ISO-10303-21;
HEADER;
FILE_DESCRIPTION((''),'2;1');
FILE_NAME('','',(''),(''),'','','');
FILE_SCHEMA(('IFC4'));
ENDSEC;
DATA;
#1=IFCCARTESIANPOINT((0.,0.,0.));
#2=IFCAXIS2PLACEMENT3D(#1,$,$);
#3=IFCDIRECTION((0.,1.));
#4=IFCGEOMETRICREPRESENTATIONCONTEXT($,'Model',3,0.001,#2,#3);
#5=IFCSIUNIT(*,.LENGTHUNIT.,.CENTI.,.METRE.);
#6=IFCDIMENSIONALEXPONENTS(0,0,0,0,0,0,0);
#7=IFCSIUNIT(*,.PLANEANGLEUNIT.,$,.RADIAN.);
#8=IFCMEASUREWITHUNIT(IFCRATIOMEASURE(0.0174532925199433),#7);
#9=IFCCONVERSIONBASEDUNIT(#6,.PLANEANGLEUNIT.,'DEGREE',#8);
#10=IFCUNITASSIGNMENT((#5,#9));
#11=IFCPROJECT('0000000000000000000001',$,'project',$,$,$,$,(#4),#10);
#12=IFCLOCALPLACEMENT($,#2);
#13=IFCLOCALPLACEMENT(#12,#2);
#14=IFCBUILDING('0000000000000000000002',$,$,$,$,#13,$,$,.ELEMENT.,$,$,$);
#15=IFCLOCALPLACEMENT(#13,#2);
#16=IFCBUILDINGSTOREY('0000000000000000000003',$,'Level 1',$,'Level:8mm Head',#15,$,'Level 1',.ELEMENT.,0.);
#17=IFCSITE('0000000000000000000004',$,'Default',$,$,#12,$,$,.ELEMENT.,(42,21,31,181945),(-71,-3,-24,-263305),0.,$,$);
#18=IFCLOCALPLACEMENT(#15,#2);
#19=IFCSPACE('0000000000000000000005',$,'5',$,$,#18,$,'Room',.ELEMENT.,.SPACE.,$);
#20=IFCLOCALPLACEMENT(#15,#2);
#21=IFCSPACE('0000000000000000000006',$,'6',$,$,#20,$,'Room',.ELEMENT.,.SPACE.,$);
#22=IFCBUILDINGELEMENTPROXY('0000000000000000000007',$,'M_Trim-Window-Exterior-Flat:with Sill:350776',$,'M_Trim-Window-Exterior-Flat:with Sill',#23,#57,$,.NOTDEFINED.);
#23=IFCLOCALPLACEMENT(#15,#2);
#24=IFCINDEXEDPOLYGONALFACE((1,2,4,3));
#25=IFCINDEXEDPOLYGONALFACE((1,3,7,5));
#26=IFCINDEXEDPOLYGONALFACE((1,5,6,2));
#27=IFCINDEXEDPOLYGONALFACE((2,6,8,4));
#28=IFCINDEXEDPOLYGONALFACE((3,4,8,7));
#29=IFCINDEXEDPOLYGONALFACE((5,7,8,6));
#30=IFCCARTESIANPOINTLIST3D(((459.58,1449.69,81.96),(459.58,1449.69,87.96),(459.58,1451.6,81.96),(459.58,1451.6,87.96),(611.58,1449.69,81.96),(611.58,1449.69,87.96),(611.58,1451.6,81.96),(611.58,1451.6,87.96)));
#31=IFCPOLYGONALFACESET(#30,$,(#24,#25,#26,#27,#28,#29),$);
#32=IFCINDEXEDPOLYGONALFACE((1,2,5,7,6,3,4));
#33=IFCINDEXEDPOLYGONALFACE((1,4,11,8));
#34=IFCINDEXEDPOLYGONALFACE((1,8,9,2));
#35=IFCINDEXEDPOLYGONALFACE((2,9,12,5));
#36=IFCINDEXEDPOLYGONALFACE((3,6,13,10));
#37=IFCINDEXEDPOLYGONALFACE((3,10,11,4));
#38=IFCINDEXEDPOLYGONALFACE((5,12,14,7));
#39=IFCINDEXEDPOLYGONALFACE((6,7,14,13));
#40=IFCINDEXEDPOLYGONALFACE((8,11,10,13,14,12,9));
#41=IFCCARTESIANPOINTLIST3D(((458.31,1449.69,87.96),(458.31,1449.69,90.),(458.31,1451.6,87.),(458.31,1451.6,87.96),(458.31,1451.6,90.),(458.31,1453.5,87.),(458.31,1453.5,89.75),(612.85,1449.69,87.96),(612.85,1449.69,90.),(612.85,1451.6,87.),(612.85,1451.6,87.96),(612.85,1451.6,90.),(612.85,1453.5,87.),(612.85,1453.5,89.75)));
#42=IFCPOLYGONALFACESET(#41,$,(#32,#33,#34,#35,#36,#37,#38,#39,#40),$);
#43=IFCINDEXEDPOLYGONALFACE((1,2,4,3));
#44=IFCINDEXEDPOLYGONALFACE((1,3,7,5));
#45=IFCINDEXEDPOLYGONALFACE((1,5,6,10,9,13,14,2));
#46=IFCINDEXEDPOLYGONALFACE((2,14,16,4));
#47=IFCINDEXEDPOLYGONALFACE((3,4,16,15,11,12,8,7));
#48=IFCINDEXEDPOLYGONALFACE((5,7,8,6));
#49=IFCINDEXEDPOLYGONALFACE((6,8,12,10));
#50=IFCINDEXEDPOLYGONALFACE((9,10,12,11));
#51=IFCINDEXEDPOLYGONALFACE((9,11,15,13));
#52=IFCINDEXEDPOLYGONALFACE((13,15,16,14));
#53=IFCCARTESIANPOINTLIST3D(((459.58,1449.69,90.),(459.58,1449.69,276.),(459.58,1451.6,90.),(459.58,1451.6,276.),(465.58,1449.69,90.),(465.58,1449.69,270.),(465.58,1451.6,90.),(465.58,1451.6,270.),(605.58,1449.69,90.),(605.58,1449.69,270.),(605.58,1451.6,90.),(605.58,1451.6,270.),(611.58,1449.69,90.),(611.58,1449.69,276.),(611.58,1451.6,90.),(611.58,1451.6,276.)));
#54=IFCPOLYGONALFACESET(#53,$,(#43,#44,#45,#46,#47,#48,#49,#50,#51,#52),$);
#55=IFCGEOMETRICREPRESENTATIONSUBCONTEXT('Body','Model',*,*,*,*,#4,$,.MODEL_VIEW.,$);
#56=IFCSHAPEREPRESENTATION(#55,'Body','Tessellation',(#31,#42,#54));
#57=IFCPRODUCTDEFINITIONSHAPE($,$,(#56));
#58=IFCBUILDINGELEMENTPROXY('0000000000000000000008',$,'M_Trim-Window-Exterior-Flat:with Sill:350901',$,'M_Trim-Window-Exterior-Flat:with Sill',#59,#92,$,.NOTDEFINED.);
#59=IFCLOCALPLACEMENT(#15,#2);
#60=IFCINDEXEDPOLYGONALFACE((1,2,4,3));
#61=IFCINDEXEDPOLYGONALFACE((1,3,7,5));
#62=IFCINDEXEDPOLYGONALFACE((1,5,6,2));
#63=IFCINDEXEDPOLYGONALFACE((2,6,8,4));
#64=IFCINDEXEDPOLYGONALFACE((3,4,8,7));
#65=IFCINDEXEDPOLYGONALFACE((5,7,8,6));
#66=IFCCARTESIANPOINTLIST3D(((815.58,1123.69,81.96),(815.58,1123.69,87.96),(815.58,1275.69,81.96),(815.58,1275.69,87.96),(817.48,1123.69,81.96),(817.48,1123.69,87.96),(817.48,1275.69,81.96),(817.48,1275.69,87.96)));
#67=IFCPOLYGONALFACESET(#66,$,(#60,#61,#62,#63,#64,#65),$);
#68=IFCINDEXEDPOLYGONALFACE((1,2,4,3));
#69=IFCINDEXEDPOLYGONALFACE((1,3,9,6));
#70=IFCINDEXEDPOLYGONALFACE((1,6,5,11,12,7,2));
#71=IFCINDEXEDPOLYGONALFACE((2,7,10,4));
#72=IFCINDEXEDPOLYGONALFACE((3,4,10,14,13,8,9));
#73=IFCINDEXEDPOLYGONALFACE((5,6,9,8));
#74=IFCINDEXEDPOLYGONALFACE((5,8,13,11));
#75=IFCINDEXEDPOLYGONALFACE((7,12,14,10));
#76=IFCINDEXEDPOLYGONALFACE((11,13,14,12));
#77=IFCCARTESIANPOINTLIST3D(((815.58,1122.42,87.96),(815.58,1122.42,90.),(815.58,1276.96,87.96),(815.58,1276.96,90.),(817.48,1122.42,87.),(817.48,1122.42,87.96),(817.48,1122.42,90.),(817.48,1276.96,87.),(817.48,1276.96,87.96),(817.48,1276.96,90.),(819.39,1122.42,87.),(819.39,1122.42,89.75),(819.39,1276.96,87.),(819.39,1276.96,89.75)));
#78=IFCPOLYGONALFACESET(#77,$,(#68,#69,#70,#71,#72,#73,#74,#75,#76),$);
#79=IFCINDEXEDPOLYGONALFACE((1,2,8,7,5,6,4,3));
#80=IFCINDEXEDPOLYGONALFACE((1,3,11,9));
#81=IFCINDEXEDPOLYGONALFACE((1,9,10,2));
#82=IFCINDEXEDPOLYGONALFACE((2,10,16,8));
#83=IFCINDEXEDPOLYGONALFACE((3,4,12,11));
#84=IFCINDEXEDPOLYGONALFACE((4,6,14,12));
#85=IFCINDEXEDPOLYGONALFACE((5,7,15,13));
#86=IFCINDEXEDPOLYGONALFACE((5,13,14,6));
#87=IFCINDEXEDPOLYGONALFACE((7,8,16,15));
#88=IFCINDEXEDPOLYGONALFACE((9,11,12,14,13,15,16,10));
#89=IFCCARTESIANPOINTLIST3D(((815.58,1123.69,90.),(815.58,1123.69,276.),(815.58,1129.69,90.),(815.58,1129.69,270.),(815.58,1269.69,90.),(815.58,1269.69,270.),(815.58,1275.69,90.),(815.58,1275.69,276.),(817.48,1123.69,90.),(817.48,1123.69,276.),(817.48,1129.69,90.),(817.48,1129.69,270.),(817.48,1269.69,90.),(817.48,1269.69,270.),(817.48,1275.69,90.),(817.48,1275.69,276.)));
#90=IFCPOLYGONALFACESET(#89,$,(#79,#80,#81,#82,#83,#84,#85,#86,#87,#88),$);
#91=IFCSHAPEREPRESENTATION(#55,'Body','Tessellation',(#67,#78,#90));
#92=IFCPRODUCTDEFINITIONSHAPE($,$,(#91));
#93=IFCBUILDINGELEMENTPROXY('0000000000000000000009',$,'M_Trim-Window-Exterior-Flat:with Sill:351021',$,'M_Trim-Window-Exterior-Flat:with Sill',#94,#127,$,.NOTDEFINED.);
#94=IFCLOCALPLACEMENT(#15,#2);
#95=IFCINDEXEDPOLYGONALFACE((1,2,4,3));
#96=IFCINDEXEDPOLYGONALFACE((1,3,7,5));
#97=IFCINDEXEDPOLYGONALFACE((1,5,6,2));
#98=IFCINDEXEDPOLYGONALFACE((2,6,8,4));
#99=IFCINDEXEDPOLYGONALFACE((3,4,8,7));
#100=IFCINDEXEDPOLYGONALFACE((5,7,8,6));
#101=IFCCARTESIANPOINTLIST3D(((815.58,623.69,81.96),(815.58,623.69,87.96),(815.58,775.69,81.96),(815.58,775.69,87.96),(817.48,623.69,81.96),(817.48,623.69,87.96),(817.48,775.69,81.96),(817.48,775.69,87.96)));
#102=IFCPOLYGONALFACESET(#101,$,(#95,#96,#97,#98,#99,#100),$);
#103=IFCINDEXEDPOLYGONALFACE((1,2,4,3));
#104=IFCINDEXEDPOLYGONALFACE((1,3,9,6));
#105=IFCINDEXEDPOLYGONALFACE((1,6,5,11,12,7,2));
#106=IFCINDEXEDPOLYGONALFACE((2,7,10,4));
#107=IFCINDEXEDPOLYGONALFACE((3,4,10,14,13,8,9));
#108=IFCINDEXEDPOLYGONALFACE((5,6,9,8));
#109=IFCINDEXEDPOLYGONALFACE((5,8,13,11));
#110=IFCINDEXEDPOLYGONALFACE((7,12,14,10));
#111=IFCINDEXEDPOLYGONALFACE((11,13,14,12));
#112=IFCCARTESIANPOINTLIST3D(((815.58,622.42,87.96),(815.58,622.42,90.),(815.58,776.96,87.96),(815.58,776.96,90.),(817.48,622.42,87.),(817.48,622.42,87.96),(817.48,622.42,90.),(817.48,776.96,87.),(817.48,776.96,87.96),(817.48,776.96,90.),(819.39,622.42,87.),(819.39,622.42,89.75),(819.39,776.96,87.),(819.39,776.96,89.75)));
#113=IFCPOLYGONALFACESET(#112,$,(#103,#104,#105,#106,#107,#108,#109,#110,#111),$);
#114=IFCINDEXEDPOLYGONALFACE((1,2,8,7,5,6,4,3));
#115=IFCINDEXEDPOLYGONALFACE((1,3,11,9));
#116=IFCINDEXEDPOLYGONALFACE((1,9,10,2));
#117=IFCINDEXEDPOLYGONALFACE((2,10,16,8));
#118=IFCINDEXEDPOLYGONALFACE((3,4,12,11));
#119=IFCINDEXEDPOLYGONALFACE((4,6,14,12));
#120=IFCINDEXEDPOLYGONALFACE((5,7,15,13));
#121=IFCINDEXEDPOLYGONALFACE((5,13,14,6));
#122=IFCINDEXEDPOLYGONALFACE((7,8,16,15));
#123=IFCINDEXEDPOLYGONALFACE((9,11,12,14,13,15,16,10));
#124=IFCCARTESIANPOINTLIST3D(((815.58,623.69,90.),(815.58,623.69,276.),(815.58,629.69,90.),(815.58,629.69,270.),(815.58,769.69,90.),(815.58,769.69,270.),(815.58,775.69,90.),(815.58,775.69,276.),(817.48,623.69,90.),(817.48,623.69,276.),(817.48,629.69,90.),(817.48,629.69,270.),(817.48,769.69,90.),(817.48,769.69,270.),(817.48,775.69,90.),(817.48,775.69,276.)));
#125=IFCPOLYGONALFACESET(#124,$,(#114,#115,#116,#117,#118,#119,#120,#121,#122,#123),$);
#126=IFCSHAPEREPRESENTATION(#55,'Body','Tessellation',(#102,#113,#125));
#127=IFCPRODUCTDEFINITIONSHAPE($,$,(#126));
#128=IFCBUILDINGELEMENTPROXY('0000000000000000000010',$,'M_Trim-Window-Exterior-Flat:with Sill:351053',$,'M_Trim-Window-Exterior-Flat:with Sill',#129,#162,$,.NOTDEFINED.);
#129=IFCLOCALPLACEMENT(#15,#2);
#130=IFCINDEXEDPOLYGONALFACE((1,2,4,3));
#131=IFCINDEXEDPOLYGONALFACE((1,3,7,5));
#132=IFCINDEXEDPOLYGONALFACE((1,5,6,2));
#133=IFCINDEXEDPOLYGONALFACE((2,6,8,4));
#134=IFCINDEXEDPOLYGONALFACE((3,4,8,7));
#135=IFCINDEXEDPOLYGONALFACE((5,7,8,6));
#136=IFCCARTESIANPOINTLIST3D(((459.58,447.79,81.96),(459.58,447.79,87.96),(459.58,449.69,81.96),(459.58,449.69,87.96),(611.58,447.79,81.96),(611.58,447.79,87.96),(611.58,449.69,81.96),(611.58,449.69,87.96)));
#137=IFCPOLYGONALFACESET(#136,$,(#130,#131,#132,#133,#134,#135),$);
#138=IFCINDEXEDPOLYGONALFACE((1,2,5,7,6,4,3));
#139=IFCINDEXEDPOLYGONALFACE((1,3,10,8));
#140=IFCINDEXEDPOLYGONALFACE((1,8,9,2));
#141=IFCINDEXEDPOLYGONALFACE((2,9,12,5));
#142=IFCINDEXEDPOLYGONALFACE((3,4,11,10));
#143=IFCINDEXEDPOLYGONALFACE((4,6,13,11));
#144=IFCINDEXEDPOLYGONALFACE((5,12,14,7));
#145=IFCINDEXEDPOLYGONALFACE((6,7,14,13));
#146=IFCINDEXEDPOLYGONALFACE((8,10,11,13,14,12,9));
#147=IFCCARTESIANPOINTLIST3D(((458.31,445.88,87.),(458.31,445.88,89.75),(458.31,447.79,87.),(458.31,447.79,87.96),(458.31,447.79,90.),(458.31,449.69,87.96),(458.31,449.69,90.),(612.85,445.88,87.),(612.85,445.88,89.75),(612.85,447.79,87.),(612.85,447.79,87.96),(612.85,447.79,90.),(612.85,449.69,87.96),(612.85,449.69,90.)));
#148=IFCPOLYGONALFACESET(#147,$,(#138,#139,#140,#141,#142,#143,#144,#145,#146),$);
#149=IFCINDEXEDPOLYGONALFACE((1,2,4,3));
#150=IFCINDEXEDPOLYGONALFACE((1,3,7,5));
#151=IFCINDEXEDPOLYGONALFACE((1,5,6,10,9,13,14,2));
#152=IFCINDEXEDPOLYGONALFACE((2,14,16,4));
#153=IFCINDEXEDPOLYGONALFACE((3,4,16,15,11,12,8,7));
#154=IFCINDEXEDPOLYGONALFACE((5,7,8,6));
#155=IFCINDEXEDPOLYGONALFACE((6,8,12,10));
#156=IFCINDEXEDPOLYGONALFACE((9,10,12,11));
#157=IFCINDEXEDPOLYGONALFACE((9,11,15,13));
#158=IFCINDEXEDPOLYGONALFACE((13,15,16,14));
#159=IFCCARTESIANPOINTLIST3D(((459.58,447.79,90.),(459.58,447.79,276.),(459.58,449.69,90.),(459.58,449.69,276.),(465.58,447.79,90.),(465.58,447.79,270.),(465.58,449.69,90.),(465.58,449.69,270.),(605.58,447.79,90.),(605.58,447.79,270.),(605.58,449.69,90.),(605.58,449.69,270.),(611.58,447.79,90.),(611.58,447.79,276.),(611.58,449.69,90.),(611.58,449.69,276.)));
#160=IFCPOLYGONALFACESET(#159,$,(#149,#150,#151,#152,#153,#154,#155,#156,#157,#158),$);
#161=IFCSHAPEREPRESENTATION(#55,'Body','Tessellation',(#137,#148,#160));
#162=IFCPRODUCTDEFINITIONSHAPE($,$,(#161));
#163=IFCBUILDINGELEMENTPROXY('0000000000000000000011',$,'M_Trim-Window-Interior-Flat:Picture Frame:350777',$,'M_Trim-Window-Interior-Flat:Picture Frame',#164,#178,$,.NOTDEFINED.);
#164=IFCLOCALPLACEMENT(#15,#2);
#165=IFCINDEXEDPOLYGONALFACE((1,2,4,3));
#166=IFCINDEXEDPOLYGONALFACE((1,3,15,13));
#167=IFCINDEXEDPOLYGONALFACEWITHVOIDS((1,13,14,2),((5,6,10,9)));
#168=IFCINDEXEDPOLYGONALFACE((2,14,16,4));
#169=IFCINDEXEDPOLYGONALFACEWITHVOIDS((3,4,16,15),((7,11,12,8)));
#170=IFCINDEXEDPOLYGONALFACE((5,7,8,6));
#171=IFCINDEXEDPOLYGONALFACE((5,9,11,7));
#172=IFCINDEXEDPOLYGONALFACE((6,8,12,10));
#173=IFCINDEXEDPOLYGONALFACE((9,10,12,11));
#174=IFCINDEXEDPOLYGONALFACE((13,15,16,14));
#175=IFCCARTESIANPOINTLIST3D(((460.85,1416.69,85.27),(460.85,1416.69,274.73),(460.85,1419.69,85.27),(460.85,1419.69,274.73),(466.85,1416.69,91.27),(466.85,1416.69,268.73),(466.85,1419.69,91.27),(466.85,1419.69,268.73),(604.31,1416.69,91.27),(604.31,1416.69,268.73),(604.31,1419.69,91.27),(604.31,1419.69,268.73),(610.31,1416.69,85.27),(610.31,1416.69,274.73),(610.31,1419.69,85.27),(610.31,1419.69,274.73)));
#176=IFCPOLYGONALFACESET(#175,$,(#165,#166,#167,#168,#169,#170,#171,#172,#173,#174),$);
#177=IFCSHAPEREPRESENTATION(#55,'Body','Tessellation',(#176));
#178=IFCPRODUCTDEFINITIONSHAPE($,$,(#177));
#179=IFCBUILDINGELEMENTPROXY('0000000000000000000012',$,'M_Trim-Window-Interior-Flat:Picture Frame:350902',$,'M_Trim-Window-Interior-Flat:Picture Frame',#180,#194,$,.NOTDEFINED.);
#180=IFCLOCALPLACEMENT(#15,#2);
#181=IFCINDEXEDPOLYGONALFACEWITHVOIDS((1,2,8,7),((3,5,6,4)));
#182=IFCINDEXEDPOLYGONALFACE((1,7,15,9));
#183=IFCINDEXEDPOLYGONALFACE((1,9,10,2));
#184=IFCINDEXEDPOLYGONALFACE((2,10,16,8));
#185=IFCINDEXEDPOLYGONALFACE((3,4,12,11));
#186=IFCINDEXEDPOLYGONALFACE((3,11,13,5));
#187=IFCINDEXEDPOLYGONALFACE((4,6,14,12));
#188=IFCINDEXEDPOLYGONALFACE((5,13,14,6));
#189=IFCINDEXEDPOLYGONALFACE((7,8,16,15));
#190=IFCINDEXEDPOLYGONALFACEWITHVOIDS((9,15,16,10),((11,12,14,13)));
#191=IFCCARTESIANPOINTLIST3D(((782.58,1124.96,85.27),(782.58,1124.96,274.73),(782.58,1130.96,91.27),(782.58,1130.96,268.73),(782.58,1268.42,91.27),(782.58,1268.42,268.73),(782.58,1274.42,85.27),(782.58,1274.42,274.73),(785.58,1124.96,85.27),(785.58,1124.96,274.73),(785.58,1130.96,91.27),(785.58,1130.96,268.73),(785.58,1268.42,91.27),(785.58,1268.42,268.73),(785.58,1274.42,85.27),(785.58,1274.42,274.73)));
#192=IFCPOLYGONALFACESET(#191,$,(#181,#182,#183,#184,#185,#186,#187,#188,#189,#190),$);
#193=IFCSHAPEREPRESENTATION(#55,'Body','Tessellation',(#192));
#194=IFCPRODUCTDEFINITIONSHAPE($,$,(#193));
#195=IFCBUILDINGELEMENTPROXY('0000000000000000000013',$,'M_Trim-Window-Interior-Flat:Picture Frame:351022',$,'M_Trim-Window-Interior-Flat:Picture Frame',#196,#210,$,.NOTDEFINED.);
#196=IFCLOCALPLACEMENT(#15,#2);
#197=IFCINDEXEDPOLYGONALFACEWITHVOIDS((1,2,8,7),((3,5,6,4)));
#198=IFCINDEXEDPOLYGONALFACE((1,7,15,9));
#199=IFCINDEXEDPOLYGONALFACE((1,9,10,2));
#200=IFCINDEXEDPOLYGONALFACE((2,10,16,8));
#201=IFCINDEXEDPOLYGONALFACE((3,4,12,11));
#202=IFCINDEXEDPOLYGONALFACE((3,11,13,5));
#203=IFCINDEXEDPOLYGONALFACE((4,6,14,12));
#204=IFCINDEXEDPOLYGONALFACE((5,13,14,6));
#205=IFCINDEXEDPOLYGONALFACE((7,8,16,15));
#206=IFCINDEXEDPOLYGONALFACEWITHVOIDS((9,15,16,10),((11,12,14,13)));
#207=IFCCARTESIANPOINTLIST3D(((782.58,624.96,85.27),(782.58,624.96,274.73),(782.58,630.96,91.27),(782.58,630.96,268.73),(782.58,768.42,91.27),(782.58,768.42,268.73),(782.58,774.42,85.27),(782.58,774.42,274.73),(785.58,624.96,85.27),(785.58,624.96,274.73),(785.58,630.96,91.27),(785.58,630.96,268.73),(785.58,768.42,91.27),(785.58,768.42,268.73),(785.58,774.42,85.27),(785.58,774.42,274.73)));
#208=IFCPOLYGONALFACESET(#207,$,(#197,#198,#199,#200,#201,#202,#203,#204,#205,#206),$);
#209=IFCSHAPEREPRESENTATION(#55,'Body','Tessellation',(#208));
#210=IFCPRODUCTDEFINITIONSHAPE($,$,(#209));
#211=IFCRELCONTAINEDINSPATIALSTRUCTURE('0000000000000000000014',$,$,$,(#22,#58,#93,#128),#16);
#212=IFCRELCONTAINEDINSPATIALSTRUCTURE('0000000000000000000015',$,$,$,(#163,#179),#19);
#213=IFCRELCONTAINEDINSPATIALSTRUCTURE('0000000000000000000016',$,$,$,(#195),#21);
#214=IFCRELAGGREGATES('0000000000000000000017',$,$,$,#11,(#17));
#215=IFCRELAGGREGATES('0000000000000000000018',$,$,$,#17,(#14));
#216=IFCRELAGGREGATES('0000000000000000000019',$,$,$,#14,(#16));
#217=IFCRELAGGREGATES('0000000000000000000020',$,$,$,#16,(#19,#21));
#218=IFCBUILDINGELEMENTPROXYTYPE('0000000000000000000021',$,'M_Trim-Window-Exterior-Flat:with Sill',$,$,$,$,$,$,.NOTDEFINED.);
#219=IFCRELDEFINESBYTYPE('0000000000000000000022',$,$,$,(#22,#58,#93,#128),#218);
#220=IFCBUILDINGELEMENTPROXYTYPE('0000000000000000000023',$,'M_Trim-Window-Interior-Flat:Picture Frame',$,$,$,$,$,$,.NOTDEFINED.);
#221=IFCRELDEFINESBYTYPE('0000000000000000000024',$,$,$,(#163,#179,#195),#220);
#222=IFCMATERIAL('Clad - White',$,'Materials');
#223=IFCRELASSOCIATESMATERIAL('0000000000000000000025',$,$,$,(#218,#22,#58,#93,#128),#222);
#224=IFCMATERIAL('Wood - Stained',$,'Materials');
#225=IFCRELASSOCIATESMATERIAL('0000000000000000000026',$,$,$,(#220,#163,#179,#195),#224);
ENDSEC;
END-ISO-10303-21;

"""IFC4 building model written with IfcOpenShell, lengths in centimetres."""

from ifc_helpers import new_model, entity, si_unit, converted_unit, direction, frame, frame_2d, origin, place, context, subcontext, project, spatial, polyline, rectangle, outline, extrude, source, transform, mapped, material, type_object, type_shapes, element, save


model = new_model("IFC4")

# Units and contexts
model_context = context("Model", 3, precision=0.001, world=origin(), true_north=direction((0.0, 1.0)))
body_context = subcontext(model_context, "Body", "Model", "MODEL_VIEW")
ifc_project = project(units=[si_unit("LENGTHUNIT", "METRE", prefix="CENTI"), converted_unit("PLANEANGLEUNIT", "DEGREE", entity("IfcRatioMeasure", 0.0174532925199433), si_unit("PLANEANGLEUNIT", "RADIAN"), dimensions=[0, 0, 0, 0, 0, 0, 0])], contexts=[model_context])

# Site, building, storey
site_placement = place(None, origin())
site = spatial("IfcSite", under=ifc_project, at=site_placement, Name="Default", CompositionType="ELEMENT", RefLatitude=(42, 21, 31, 181945), RefLongitude=(-71, -3, -24, -263305), RefElevation=0.0)
building_placement = place(site_placement, origin())
building = spatial("IfcBuilding", under=site, at=building_placement, CompositionType="ELEMENT")
storey_placement = place(building_placement, origin())
storey = spatial("IfcBuildingStorey", under=building, at=storey_placement, Name="Level 1", ObjectType="Level:8mm Head", LongName="Level 1", CompositionType="ELEMENT", Elevation=0.0)

# Building element proxies
ifc_material_1 = material(Name="Clad - White", Category="Materials")
building_element_proxy_type_1 = type_object("IfcBuildingElementProxyType", Name="M_Trim-Window-Exterior-Flat:with Sill", PredefinedType="NOTDEFINED", material=ifc_material_1)
shared_shape_1 = source(origin(), body_context, "Body", "SweptSolid", [
    extrude(rectangle(XDim=152.0, YDim=6.0, at=frame_2d((0.0, 0.0), x_axis=(1.0, 0.0))), frame((0.0, -185.04, 0.0), z_axis=(0.0, 0.0, 1.0), x_axis=(-1.0, 0.0, 0.0)), (0.0, 0.0, 1.0), 1.91),
    extrude(outline(polyline([(-1.9, -1.52), (0.0, -1.52), (0.0, -0.57), (1.9, -0.57), (1.9, 1.48), (0.0, 1.48), (-1.9, 1.23), (-1.9, -1.52)])), frame((-77.27, -181.48, 1.9), z_axis=(1.0, 0.0, 0.0), x_axis=(0.0, 0.0, -1.0)), (0.0, 0.0, 1.0), 154.54),
    extrude(outline(polyline([(-94.5, -76.0), (91.5, -76.0), (91.5, -70.0), (-88.5, -70.0), (-88.5, 70.0), (91.5, 70.0), (91.5, 76.0), (-94.5, 76.0), (-94.5, -76.0)])), frame((0.0, -88.5, 0.0), z_axis=(0.0, 0.0, 1.0), x_axis=(0.0, -1.0, 0.0)), (0.0, 0.0, 1.0), 1.91),
])
type_shapes(building_element_proxy_type_1, [shared_shape_1])
for number, where, z_axis, x_axis, name in (
    (1, (535.58, 1449.69, 270.0), (0.0, 1.0, 0.0), (-1.0, 0.0, 0.0), "M_Trim-Window-Exterior-Flat:with Sill:350776"),
    (2, (815.58, 1199.69, 270.0), (1.0, 0.0, 0.0), (0.0, 1.0, 0.0), "M_Trim-Window-Exterior-Flat:with Sill:350901"),
    (3, (815.58, 699.69, 270.0), (1.0, 0.0, 0.0), (0.0, 1.0, 0.0), "M_Trim-Window-Exterior-Flat:with Sill:351021"),
    (4, (535.58, 449.69, 270.0), (0.0, -1.0, 0.0), (1.0, 0.0, 0.0), "M_Trim-Window-Exterior-Flat:with Sill:351053"),
):
    element("IfcBuildingElementProxy", number, at=place(storey_placement, frame(where, z_axis=z_axis, x_axis=x_axis)), inside=storey, type_object=building_element_proxy_type_1, material=ifc_material_1, Name=name, ObjectType="M_Trim-Window-Exterior-Flat:with Sill", PredefinedType="NOTDEFINED", context=body_context, shape_type="MappedRepresentation", body=[
        mapped(shared_shape_1, transform((0.0, 0.0, 0.0), scale=1.0)),
    ])

# Shared definitions
space_1_placement = place(storey_placement, origin())
space_1 = spatial("IfcSpace", under=storey, at=space_1_placement, Name="5", LongName="Room", CompositionType="ELEMENT", PredefinedType="SPACE")

# Building element proxies
ifc_material_2 = material(Name="Wood - Stained", Category="Materials")
building_element_proxy_type_2 = type_object("IfcBuildingElementProxyType", Name="M_Trim-Window-Interior-Flat:Picture Frame", PredefinedType="NOTDEFINED", material=ifc_material_2)
shared_shape_2 = source(origin(), body_context, "Body", "SweptSolid", [
    extrude(outline(polyline([(-74.73, -94.73), (74.73, -94.73), (74.73, 94.73), (-74.73, 94.73), (-74.73, -94.73)]), holes=[polyline([(-68.73, -88.73), (-68.73, 88.73), (68.73, 88.73), (68.73, -88.73), (-68.73, -88.73)])]), frame((0.0, -90.0, 0.0), z_axis=(0.0, 0.0, 1.0), x_axis=(-1.0, 0.0, 0.0)), (0.0, 0.0, 1.0), 3.0),
])
type_shapes(building_element_proxy_type_2, [shared_shape_2])
for number, where, z_axis, x_axis, name in (
    (5, (535.58, 1419.69, 270.0), (0.0, -1.0, 0.0), (1.0, 0.0, 0.0), "M_Trim-Window-Interior-Flat:Picture Frame:350777"),
    (6, (785.58, 1199.69, 270.0), (-1.0, 0.0, 0.0), (0.0, -1.0, 0.0), "M_Trim-Window-Interior-Flat:Picture Frame:350902"),
):
    element("IfcBuildingElementProxy", number, at=place(space_1_placement, frame(where, z_axis=z_axis, x_axis=x_axis)), inside=space_1, type_object=building_element_proxy_type_2, material=ifc_material_2, Name=name, ObjectType="M_Trim-Window-Interior-Flat:Picture Frame", PredefinedType="NOTDEFINED", context=body_context, shape_type="MappedRepresentation", body=[
        mapped(shared_shape_2, transform((0.0, 0.0, 0.0), scale=1.0)),
    ])

# Shared definitions
space_2_placement = place(storey_placement, origin())
space_2 = spatial("IfcSpace", under=storey, at=space_2_placement, Name="6", LongName="Room", CompositionType="ELEMENT", PredefinedType="SPACE")

# Building element proxy
for number, where, z_axis, x_axis, name in (
    (7, (785.58, 699.69, 270.0), (-1.0, 0.0, 0.0), (0.0, -1.0, 0.0), "M_Trim-Window-Interior-Flat:Picture Frame:351022"),
):
    element("IfcBuildingElementProxy", number, at=place(space_2_placement, frame(where, z_axis=z_axis, x_axis=x_axis)), inside=space_2, type_object=building_element_proxy_type_2, material=ifc_material_2, Name=name, ObjectType="M_Trim-Window-Interior-Flat:Picture Frame", PredefinedType="NOTDEFINED", context=body_context, shape_type="MappedRepresentation", body=[
        mapped(shared_shape_2, transform((0.0, 0.0, 0.0), scale=1.0)),
    ])

save(model, "model.ifc")
